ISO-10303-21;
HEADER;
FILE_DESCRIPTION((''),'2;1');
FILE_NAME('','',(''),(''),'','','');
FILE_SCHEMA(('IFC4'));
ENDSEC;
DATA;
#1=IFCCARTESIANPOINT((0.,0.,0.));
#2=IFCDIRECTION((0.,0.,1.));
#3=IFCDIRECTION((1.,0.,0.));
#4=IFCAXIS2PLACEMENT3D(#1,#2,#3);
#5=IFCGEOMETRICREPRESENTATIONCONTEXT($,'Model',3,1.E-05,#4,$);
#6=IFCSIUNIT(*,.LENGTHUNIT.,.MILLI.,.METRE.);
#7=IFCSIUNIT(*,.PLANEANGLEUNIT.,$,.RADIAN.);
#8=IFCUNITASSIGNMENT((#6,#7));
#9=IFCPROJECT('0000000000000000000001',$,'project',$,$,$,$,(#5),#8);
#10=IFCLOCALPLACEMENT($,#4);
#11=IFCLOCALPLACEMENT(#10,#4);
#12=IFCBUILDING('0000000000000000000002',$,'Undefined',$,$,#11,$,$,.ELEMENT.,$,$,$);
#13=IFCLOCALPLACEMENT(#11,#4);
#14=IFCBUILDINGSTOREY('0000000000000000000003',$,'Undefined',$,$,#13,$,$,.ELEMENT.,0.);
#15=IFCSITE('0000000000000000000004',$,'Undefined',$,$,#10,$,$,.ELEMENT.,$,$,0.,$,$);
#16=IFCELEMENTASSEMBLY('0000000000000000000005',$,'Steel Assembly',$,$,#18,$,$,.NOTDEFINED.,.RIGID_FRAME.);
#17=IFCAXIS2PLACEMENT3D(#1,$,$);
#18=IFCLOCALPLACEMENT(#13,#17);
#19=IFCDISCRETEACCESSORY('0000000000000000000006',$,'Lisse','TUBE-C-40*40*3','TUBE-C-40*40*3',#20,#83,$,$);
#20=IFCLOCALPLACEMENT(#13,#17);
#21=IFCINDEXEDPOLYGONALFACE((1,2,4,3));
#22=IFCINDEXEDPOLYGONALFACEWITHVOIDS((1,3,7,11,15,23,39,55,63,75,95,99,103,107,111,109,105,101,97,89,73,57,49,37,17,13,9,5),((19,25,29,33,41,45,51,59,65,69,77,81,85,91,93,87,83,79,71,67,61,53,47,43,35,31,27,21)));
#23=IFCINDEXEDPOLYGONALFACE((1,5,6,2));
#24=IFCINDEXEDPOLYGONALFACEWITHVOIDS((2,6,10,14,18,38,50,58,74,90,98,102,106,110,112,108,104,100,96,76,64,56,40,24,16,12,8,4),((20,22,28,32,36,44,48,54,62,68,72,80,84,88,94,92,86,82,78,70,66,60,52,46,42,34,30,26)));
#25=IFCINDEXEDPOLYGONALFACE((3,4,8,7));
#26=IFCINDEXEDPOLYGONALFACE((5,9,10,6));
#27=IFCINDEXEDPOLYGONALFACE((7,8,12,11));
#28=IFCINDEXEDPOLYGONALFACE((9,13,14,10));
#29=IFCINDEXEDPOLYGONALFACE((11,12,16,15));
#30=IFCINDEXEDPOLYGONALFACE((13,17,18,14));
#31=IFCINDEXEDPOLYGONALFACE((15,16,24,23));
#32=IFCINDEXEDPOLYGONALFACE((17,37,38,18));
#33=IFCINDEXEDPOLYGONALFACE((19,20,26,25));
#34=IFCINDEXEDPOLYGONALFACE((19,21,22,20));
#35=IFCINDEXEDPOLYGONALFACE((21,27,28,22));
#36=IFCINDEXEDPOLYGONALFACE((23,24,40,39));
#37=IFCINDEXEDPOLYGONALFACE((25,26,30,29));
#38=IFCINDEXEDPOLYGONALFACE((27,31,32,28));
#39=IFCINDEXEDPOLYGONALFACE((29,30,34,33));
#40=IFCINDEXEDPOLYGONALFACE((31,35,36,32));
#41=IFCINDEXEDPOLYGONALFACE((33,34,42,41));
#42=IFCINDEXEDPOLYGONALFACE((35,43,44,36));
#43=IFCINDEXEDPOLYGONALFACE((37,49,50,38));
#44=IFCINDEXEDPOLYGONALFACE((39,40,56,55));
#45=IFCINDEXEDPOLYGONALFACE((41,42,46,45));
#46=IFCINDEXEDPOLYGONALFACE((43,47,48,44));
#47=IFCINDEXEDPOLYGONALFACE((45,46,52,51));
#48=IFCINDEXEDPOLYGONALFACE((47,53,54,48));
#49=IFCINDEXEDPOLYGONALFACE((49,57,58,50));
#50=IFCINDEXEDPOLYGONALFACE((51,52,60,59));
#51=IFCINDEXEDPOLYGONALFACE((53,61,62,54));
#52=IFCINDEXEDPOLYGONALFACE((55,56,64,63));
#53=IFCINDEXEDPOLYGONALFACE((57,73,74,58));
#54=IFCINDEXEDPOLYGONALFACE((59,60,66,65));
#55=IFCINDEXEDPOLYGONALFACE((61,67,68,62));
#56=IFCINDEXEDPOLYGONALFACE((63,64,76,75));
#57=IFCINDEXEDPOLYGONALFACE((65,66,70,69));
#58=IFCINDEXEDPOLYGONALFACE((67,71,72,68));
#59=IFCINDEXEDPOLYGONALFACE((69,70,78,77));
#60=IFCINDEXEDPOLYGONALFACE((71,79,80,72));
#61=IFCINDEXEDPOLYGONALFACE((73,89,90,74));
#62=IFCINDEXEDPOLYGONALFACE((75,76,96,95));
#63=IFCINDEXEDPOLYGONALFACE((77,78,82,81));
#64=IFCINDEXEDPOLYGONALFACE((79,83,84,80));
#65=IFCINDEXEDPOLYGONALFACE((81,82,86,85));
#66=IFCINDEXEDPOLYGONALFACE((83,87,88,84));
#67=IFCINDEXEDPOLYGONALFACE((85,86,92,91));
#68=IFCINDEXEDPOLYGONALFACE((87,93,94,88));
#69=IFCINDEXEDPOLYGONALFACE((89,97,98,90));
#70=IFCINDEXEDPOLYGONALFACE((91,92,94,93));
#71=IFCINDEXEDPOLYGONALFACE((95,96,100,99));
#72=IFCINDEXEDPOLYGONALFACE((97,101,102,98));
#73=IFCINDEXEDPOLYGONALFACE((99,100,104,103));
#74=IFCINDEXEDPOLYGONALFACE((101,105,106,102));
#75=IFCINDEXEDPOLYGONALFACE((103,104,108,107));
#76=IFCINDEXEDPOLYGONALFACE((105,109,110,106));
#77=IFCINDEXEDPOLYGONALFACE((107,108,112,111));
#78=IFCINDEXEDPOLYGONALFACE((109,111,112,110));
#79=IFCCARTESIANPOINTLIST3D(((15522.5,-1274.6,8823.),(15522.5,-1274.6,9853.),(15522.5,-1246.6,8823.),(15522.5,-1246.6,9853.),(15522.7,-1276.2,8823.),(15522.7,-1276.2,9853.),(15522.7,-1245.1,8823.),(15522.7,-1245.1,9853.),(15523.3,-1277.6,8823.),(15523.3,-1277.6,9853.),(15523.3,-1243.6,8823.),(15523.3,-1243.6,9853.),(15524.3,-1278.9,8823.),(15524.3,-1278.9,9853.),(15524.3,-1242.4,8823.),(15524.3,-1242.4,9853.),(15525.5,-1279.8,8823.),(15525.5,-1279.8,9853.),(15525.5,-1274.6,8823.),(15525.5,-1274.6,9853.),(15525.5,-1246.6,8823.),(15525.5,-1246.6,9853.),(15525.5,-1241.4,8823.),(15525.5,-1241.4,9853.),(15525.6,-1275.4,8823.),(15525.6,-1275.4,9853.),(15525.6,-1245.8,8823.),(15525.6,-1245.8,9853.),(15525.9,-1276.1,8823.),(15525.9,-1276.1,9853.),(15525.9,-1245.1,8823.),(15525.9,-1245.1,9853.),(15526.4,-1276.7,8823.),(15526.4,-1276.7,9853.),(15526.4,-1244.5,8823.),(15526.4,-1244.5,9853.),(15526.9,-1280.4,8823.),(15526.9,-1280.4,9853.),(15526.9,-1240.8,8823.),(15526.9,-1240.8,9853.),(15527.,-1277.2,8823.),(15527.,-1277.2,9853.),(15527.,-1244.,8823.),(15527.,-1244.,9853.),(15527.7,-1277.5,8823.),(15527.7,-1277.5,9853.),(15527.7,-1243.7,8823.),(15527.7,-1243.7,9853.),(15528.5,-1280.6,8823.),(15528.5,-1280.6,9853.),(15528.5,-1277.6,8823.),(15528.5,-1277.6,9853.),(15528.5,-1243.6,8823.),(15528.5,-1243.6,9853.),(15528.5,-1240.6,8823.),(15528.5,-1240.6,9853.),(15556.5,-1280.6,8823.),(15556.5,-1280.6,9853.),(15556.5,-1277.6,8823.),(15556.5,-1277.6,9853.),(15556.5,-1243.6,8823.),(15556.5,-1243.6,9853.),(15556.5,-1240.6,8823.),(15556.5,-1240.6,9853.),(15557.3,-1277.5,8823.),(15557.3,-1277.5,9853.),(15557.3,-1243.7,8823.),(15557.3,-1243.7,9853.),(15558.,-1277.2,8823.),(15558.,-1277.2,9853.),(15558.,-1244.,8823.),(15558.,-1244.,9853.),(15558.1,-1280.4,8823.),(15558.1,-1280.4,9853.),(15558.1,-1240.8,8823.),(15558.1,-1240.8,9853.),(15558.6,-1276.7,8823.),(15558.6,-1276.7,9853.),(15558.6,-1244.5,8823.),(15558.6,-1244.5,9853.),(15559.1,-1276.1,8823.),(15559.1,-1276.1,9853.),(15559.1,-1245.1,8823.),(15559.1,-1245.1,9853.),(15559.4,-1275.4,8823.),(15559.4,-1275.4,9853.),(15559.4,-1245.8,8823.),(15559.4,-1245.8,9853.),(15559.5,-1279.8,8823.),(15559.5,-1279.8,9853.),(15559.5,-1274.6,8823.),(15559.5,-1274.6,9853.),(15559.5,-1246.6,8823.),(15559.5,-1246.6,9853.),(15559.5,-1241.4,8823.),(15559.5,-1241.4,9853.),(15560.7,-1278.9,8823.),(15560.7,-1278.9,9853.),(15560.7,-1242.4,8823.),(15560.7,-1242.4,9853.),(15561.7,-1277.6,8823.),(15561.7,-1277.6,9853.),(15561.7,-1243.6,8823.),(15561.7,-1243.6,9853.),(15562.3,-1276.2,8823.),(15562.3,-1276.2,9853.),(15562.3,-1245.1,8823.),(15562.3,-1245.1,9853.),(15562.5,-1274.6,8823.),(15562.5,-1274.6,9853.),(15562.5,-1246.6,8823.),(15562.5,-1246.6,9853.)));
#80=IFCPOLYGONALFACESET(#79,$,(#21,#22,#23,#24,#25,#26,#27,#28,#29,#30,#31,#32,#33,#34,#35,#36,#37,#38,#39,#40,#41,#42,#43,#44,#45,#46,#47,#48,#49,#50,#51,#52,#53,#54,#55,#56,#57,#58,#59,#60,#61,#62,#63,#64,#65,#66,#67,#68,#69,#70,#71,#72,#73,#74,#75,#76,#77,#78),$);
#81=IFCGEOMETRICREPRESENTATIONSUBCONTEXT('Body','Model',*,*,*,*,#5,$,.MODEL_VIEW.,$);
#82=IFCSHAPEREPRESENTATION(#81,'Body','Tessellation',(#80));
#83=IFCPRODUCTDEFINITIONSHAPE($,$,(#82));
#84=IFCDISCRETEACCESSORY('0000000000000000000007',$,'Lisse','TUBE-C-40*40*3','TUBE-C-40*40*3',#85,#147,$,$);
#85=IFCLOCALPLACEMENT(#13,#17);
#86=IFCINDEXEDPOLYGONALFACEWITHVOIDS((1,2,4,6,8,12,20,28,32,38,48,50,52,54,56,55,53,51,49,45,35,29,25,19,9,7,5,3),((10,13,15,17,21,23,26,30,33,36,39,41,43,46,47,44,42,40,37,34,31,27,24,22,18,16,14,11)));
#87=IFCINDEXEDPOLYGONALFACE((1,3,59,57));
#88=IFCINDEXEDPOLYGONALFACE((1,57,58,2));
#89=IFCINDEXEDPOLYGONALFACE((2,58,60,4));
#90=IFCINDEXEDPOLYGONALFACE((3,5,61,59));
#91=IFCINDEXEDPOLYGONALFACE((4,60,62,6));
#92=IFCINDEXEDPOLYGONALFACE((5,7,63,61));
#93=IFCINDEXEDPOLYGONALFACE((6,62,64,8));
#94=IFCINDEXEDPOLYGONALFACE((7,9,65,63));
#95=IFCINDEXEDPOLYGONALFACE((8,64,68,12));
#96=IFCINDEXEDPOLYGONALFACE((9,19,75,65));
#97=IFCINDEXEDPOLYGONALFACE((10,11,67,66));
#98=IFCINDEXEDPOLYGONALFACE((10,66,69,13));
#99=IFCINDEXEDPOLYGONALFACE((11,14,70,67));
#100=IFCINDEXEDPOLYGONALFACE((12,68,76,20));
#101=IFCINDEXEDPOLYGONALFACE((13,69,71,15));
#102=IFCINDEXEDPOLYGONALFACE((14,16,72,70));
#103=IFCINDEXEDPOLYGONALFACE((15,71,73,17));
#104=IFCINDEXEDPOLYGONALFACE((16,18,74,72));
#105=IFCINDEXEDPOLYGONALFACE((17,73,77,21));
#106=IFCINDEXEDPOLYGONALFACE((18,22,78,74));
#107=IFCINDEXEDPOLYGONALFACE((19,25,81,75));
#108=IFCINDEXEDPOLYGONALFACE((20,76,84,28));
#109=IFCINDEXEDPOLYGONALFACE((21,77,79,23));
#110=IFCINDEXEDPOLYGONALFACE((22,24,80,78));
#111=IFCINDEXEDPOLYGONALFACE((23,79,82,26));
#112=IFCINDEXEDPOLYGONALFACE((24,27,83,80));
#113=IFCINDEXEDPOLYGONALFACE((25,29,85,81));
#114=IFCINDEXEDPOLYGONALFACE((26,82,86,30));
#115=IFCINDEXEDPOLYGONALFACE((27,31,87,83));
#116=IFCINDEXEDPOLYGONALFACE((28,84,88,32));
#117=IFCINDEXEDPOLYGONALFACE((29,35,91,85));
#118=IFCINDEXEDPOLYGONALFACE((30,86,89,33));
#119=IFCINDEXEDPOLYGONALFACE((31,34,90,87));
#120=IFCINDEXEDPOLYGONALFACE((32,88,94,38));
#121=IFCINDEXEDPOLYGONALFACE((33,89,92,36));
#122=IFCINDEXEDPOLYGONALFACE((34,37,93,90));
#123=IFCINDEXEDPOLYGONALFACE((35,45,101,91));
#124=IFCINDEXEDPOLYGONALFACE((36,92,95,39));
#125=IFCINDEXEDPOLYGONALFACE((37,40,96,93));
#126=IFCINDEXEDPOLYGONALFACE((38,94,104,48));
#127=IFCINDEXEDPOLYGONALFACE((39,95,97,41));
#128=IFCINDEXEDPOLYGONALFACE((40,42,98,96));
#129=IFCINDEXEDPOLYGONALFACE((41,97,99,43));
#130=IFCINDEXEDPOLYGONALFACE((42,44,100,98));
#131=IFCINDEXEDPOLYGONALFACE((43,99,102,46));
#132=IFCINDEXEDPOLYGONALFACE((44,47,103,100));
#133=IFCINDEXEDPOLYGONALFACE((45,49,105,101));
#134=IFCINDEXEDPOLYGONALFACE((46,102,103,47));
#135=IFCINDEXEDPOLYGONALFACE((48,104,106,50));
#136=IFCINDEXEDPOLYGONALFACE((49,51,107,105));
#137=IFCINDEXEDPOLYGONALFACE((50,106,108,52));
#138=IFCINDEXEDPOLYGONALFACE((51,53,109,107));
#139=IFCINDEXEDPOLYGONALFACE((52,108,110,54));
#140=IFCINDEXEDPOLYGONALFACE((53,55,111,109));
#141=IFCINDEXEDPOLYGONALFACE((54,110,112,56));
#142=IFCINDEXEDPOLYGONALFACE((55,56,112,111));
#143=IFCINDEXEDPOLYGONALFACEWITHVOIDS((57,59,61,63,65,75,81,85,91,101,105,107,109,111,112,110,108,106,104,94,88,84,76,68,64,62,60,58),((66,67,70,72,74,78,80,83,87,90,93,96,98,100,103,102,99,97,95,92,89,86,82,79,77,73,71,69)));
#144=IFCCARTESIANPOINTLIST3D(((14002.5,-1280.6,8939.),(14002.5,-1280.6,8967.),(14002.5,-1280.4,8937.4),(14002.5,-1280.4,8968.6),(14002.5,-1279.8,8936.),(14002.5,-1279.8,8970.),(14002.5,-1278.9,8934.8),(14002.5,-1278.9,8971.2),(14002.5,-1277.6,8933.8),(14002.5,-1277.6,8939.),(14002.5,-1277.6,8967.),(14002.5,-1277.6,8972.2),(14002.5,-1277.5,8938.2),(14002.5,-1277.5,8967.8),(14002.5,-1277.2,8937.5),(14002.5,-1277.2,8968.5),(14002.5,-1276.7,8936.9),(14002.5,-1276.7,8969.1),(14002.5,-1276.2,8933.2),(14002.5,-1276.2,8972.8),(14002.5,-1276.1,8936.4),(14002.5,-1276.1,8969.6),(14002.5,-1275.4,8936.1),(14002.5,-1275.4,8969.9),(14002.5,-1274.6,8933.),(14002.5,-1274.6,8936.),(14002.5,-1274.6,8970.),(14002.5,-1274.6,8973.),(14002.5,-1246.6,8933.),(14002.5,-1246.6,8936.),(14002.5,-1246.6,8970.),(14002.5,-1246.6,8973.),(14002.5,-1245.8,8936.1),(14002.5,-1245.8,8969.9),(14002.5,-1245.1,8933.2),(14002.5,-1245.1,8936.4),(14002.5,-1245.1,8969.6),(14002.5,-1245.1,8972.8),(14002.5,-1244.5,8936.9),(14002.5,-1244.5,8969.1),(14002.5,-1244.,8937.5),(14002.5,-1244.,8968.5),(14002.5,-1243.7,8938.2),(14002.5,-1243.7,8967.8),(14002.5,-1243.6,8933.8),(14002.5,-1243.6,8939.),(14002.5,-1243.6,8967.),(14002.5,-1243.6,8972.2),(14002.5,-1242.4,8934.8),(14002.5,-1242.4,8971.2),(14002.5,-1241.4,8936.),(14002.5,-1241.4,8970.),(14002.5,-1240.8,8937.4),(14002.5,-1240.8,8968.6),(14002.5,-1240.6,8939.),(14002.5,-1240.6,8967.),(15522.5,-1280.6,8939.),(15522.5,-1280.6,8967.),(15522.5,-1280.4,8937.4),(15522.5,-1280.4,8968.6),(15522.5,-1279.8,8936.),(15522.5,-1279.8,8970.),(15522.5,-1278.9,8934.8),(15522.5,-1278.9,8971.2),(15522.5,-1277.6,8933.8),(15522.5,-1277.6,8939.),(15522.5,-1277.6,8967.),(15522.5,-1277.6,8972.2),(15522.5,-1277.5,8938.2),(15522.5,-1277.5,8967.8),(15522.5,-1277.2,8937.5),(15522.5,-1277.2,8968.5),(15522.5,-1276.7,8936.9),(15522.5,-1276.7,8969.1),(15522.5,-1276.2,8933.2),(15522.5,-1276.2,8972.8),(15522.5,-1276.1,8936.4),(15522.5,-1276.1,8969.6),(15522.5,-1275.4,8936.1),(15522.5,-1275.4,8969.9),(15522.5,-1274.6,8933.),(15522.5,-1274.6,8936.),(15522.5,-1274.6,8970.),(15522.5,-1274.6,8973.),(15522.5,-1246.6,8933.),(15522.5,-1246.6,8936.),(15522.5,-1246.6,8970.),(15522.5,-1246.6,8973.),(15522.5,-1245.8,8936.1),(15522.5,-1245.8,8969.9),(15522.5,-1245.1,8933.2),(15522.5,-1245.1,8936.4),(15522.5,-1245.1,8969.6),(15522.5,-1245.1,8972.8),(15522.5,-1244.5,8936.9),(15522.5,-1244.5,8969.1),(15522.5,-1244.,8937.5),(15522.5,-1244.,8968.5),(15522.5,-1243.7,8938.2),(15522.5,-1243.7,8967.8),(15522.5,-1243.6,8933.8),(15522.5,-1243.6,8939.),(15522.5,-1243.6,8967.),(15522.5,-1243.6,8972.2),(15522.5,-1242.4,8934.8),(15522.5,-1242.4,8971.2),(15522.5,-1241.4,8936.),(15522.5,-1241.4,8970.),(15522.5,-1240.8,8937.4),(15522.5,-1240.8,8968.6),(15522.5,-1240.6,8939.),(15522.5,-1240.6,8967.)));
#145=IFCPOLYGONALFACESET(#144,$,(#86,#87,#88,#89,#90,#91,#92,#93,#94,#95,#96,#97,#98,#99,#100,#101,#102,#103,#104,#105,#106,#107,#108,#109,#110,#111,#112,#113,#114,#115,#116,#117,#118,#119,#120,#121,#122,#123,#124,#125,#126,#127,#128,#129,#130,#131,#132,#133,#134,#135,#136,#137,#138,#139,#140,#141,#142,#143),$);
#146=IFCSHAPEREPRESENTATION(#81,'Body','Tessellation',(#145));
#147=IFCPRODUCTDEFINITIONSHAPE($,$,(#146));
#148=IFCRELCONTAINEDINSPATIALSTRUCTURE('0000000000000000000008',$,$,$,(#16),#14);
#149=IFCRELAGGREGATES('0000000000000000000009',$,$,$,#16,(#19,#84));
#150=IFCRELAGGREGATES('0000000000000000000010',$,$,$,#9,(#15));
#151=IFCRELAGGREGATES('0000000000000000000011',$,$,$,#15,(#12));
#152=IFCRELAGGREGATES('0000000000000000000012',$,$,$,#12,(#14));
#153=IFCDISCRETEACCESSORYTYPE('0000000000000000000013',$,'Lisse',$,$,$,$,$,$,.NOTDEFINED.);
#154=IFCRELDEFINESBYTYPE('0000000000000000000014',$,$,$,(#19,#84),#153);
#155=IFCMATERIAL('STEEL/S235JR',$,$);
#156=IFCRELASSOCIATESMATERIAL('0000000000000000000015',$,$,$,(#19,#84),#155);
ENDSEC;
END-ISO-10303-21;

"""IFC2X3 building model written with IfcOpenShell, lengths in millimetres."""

from ifc_helpers import new_model, si_unit, frame, origin_with_axes, origin_2d_with_axis, place, context, subcontext, project, spatial, hollow_rectangle, extrude, material, type_object, element, aggregate, save


model = new_model("IFC2X3")

# Units and contexts
model_context = context("Model", 3, precision=1e-05, world=origin_with_axes())
body_context = subcontext(model_context, "Body", "Model", "MODEL_VIEW")
ifc_project = project(units=[si_unit("LENGTHUNIT", "METRE", prefix="MILLI"), si_unit("PLANEANGLEUNIT", "RADIAN")], contexts=[model_context])

# Site, building, storey
site_placement = place(None, origin_with_axes())
site = spatial("IfcSite", under=ifc_project, at=site_placement, Name="Undefined", CompositionType="ELEMENT", RefElevation=0.0)
building_placement = place(site_placement, origin_with_axes())
building = spatial("IfcBuilding", under=site, at=building_placement, Name="Undefined", CompositionType="ELEMENT")
storey_placement = place(building_placement, origin_with_axes())
storey = spatial("IfcBuildingStorey", under=building, at=storey_placement, Name="Undefined", CompositionType="ELEMENT", Elevation=0.0)

# Shared definitions
ifc_material_1 = material(Name="STEEL/S235JR")

# Element assembly
assembly_1_placement = place(storey_placement, origin_with_axes())
assembly_1 = element("IfcElementAssembly", 1, at=assembly_1_placement, inside=storey, Name="Steel Assembly", AssemblyPlace="NOTDEFINED", PredefinedType="RIGID_FRAME")

# Discrete accessories
discrete_accessory_type_1 = type_object("IfcDiscreteAccessoryType", Name="Lisse")
discrete_accessory_1_placement = place(assembly_1_placement, frame((15542.5, -1260.6, 9853.0), z_axis=(0.0, 1.0, 0.0), x_axis=(0.0, 0.0, -1.0)))
discrete_accessory_1 = element("IfcDiscreteAccessory", 2, at=discrete_accessory_1_placement, type_object=discrete_accessory_type_1, material=ifc_material_1, Name="Lisse", Description="TUBE-C-40*40*3", ObjectType="TUBE-C-40*40*3", context=body_context, shape_type="SweptSolid", body=[
    extrude(hollow_rectangle(XDim=40.0, YDim=40.0, WallThickness=3.0, InnerFilletRadius=3.0, OuterFilletRadius=6.0, at=origin_2d_with_axis()), frame((1030.0, 0.0, 0.0), z_axis=(-1.0, 0.0, 0.0), x_axis=(0.0, -1.0, 0.0)), (0.0, 0.0, 1.0), 1030.0),
])
discrete_accessory_2_placement = place(assembly_1_placement, frame((14002.5, -1260.6, 8953.0), z_axis=(0.0, 1.0, 0.0), x_axis=(1.0, 0.0, 0.0)))
discrete_accessory_2 = element("IfcDiscreteAccessory", 3, at=discrete_accessory_2_placement, type_object=discrete_accessory_type_1, material=ifc_material_1, Name="Lisse", Description="TUBE-C-40*40*3", ObjectType="TUBE-C-40*40*3", context=body_context, shape_type="SweptSolid", body=[
    extrude(hollow_rectangle(XDim=40.0, YDim=40.0, WallThickness=3.0, InnerFilletRadius=3.0, OuterFilletRadius=6.0, at=origin_2d_with_axis()), frame((1520.0, 0.0, 0.0), z_axis=(-1.0, 0.0, 0.0), x_axis=(0.0, -1.0, 0.0)), (0.0, 0.0, 1.0), 1520.0),
])
aggregate(assembly_1, [discrete_accessory_1, discrete_accessory_2])

save(model, "model.ifc")
